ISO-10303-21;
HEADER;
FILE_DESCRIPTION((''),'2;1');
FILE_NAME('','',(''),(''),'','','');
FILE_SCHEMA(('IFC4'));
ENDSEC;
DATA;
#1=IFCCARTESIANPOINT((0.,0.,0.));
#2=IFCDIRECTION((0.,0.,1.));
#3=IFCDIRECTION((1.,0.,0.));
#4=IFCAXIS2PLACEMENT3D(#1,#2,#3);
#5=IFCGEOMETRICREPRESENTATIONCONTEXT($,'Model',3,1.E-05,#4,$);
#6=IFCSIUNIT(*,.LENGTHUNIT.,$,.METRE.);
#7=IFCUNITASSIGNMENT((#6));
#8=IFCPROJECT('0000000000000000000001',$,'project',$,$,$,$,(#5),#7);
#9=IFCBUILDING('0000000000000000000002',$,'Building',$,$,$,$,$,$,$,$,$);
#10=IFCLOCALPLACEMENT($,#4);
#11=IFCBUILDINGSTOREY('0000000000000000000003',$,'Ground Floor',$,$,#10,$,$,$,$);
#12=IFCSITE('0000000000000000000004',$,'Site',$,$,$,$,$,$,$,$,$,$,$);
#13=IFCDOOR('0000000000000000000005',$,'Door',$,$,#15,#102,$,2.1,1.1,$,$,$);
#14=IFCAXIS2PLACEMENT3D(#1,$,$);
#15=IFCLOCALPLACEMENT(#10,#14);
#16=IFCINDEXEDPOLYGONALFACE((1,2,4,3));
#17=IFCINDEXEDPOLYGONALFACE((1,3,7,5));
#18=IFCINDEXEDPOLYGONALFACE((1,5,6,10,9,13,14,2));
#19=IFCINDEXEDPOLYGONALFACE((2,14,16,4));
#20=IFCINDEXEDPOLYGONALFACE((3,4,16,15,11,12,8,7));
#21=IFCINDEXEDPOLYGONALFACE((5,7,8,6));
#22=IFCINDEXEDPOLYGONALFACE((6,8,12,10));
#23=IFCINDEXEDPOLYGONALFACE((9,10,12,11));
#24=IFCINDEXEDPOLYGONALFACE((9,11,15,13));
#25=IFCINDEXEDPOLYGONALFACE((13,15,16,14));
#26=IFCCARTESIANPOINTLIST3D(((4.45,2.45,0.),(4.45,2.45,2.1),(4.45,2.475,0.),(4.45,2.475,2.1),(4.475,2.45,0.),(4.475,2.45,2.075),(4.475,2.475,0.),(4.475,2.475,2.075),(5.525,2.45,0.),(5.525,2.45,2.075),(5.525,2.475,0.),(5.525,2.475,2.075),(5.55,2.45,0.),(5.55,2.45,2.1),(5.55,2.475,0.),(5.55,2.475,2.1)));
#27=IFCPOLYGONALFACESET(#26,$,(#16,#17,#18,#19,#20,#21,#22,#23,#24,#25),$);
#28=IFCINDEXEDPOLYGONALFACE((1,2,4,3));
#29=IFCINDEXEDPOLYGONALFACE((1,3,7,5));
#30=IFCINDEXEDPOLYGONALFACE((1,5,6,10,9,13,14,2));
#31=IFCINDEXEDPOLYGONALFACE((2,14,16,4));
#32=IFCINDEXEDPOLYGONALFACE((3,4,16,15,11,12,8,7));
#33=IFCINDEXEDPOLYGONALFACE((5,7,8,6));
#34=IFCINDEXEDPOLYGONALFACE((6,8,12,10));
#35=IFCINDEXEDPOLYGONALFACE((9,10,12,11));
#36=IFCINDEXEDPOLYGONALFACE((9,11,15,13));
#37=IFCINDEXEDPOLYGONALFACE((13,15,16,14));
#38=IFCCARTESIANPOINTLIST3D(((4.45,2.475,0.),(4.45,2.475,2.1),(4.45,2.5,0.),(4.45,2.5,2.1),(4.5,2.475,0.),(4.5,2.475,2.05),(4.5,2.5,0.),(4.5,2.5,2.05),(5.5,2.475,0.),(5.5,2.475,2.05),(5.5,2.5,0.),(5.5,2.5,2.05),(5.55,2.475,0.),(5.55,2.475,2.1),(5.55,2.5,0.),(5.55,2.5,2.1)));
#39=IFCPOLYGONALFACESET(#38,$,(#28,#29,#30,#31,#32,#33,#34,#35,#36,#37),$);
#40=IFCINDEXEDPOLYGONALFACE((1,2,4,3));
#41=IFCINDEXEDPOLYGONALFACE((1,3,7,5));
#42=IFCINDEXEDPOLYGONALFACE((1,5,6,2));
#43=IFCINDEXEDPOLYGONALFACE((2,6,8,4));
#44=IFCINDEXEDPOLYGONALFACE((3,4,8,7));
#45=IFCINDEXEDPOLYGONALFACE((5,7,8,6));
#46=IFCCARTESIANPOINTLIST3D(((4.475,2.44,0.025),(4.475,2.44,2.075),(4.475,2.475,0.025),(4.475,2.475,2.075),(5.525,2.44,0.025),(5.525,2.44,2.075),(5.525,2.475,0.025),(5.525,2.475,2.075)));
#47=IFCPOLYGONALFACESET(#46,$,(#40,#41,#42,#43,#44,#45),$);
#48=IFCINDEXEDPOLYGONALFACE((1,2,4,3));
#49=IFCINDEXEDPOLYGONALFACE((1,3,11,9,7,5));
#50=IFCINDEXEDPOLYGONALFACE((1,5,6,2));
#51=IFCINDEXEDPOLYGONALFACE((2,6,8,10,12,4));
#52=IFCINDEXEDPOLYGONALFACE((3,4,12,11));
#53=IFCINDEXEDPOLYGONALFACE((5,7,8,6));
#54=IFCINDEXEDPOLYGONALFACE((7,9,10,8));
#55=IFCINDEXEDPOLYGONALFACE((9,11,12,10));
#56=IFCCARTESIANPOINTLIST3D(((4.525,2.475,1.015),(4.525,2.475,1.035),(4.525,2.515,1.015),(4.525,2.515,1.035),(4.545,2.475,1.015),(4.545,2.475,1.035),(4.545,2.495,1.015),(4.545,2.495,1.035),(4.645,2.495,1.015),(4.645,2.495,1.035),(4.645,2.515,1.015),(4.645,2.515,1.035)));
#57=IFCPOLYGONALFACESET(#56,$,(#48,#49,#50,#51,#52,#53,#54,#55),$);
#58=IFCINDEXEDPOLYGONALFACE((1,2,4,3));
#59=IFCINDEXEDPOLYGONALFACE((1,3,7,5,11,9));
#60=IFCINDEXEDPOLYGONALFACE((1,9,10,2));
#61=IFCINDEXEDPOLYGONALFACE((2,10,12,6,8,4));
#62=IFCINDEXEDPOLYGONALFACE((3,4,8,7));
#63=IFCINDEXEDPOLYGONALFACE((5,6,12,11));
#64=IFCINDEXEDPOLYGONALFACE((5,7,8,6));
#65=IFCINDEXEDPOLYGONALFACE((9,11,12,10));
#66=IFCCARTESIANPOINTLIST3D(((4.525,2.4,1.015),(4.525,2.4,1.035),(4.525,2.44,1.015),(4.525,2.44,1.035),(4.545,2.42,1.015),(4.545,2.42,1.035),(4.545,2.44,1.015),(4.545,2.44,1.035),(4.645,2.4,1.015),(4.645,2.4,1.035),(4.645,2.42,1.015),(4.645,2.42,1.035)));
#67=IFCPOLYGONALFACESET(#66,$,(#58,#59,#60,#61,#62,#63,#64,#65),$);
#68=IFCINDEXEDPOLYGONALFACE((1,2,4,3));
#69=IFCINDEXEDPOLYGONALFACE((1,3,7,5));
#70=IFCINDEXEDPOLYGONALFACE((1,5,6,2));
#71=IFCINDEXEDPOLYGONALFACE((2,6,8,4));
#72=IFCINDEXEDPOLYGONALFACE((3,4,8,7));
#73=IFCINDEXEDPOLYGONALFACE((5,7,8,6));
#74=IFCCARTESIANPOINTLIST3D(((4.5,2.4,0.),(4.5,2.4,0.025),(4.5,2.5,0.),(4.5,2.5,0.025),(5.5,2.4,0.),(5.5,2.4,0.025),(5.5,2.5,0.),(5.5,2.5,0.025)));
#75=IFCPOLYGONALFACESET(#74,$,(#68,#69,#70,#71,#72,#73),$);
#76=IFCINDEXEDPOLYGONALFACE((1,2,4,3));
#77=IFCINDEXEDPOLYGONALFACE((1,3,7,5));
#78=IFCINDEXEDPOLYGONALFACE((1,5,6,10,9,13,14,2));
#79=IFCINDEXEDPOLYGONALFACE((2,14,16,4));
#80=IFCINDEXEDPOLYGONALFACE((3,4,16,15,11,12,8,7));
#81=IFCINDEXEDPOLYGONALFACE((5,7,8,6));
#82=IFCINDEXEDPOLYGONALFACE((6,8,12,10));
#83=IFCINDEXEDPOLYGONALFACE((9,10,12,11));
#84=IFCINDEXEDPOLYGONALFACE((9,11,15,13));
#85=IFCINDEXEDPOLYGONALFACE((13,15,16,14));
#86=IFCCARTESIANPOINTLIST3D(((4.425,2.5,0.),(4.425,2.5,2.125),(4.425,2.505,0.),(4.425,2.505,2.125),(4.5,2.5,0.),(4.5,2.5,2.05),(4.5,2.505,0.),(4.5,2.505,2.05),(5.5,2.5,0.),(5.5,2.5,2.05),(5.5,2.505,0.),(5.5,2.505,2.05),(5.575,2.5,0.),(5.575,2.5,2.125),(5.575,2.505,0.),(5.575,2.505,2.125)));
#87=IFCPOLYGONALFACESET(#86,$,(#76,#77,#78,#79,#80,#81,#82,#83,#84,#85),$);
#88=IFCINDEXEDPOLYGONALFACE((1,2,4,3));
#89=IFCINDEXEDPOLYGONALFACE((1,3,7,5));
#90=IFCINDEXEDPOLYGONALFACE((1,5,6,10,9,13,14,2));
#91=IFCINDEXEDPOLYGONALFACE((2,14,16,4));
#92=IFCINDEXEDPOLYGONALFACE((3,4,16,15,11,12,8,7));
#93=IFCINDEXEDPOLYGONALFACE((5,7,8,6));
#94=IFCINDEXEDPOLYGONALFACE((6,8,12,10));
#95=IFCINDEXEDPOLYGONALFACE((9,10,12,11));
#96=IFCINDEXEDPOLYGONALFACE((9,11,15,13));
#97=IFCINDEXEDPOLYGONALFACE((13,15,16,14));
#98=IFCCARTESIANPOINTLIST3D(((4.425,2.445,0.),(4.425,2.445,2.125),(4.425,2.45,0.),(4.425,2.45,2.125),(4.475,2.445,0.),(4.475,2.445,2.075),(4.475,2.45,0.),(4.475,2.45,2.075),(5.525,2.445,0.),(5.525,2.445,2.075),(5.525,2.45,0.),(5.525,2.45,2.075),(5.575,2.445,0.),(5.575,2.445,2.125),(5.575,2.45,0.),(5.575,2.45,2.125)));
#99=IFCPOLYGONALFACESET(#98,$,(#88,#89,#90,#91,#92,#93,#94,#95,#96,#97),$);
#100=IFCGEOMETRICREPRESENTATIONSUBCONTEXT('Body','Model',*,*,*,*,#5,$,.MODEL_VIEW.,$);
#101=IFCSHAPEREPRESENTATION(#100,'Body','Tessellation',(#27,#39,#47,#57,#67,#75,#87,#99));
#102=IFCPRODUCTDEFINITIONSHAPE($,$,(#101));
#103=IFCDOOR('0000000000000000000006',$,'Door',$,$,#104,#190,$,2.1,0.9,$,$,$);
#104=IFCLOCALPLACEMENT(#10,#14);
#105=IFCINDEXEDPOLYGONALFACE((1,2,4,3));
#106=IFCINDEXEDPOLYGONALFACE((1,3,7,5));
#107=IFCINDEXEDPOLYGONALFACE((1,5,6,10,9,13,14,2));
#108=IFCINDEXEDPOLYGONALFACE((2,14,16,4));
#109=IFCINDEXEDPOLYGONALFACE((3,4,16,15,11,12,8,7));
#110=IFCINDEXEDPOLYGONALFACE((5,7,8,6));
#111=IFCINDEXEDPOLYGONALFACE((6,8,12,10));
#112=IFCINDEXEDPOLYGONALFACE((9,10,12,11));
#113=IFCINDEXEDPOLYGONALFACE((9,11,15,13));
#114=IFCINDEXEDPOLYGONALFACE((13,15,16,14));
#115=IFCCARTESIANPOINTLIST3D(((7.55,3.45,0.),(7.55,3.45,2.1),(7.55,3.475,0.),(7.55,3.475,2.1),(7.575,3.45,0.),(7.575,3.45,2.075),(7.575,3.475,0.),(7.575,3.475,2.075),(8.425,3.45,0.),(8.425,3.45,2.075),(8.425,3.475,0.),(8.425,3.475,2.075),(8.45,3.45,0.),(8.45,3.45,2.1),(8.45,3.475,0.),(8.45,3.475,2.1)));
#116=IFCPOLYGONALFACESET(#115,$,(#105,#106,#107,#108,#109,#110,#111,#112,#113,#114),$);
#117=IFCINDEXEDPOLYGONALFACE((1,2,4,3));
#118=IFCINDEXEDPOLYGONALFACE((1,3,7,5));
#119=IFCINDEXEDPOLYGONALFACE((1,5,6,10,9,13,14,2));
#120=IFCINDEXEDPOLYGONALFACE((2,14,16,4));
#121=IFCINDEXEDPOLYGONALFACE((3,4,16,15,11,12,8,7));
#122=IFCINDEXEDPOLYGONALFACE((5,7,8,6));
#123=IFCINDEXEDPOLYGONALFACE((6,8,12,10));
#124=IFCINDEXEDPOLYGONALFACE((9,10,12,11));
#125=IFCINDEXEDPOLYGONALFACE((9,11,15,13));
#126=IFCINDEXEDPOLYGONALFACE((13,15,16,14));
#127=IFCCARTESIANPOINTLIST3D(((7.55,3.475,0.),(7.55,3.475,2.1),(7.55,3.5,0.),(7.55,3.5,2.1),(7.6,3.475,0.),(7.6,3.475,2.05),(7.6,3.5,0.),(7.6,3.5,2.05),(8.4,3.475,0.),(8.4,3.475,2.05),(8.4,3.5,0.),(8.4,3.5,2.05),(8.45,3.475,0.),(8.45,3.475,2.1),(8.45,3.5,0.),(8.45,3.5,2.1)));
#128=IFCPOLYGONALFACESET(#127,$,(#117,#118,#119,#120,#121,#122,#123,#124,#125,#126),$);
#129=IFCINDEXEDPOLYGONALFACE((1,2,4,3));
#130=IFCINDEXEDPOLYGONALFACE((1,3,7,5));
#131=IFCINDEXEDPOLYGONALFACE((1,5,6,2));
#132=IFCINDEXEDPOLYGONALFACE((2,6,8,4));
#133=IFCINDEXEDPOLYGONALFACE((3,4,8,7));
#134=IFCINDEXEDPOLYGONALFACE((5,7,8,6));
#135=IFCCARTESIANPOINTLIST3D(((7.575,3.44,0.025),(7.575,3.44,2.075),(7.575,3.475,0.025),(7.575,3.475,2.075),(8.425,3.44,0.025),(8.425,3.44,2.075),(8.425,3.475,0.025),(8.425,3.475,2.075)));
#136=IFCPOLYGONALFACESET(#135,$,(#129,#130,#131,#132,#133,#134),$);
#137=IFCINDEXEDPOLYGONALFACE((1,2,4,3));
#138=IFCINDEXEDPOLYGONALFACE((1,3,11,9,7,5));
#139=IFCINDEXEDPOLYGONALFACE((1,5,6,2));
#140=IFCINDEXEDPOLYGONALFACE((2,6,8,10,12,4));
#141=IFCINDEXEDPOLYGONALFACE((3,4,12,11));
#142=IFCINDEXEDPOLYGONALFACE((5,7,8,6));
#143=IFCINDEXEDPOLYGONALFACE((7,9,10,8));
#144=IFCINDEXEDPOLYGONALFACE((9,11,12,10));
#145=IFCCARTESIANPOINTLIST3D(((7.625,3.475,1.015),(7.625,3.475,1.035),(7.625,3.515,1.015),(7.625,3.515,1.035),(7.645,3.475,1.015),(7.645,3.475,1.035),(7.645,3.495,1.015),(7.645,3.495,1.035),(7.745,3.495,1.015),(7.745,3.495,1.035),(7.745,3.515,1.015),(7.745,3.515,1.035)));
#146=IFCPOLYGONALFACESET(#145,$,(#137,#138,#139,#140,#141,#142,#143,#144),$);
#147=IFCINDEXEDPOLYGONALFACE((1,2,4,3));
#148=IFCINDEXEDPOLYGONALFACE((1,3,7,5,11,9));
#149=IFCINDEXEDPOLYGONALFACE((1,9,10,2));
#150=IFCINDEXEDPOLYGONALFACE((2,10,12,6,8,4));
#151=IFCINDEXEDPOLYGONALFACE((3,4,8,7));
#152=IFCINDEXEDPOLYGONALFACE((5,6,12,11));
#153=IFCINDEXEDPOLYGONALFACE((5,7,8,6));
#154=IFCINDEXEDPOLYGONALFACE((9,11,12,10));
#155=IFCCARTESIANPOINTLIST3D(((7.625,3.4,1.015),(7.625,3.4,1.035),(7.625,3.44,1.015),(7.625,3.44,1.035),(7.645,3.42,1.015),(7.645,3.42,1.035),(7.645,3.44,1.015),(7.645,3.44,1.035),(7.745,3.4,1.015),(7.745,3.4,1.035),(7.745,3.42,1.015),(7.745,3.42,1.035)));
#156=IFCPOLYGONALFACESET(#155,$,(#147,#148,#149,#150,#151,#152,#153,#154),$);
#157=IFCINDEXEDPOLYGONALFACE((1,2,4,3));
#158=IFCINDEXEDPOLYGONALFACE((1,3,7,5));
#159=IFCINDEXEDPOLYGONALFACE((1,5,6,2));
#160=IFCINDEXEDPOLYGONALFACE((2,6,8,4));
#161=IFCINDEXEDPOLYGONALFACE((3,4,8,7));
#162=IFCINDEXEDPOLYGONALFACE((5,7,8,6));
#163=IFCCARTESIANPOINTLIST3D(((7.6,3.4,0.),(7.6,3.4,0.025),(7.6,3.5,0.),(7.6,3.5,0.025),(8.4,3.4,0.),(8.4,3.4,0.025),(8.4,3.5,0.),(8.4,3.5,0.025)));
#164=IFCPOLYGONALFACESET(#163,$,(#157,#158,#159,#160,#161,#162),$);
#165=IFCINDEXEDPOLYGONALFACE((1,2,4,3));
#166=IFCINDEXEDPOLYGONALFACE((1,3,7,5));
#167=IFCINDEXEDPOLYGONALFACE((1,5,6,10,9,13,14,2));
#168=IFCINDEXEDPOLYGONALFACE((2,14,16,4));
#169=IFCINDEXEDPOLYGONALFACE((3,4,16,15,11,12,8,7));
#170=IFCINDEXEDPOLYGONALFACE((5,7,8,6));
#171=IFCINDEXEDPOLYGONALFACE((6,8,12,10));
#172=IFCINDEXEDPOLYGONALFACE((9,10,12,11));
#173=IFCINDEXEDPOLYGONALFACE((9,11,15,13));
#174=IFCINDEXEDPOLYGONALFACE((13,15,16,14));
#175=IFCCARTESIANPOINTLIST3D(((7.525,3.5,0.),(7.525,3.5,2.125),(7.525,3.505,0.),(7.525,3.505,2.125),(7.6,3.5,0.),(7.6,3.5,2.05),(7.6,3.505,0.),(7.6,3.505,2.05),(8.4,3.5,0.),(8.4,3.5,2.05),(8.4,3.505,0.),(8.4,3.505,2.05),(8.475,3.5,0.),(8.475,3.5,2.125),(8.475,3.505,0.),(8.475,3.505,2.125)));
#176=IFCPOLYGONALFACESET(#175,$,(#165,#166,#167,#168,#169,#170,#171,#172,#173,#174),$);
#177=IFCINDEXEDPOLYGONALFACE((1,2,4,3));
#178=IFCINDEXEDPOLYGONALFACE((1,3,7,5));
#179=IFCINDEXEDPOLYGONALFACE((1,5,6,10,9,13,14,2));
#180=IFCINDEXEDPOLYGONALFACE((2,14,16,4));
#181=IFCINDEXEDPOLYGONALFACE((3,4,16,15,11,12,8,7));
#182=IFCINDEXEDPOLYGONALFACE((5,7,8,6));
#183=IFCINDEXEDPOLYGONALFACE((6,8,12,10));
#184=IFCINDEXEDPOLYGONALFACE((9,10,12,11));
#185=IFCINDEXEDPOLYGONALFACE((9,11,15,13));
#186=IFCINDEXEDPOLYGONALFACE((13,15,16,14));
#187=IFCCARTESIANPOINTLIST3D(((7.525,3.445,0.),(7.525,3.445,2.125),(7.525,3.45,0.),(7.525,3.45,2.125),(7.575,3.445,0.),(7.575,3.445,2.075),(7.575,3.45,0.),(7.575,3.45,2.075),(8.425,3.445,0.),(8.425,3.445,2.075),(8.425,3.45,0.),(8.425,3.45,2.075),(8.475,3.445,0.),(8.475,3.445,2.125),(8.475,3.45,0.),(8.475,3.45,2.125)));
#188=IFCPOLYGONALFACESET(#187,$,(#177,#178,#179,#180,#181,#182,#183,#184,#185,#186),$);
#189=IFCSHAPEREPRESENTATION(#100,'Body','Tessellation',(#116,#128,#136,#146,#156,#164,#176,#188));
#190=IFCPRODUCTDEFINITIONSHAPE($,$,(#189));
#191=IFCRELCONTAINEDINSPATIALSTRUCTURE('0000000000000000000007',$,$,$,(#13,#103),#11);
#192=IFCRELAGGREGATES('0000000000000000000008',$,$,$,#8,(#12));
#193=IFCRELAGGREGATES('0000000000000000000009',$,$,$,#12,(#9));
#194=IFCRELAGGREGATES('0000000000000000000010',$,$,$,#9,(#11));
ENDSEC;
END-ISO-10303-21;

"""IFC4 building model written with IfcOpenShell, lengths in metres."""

from ifc_helpers import new_model, si_unit, frame, origin_with_axes, place, context, subcontext, project, spatial, line, indexed_curve, outline, extrude, element, save


model = new_model("IFC4")

# Units and contexts
model_context = context("Model", 3, precision=1e-05, world=origin_with_axes())
body_context = subcontext(model_context, "Body", "Model", "MODEL_VIEW")
ifc_project = project(units=[si_unit("LENGTHUNIT", "METRE")], contexts=[model_context])

# Site, building, storey
site = spatial("IfcSite", under=ifc_project, Name="Site")
building = spatial("IfcBuilding", under=site, Name="Building")
storey_placement = place(None, origin_with_axes())
storey = spatial("IfcBuildingStorey", under=building, at=storey_placement, Name="Ground Floor")

# Doors
door_1_placement = place(storey_placement, frame((5.55, 2.5, 0.0), z_axis=(0.0, 0.0, 1.0), x_axis=(-1.0, 0.0, 0.0)))
element("IfcDoor", 1, at=door_1_placement, inside=storey, Name="Door", OverallHeight=2.1, OverallWidth=1.1, context=body_context, shape_type="SweptSolid", body=[
    extrude(outline(indexed_curve([(0.0, 0.0), (0.0, 2.1), (1.1, 2.1), (1.1, 0.0), (1.075, 0.0), (1.075, 2.075), (0.025, 2.075), (0.025, 0.0)], segments=[line(1, 2, 3, 4, 5, 6, 7, 8, 1)])), frame((0.0, 0.025, 0.0), z_axis=(0.0, -1.0, 0.0), x_axis=(1.0, 0.0, 0.0)), (0.0, 0.0, -1.0), 0.025),
    extrude(outline(indexed_curve([(0.0, 0.0), (0.0, 2.1), (1.1, 2.1), (1.1, 0.0), (1.05, 0.0), (1.05, 2.05), (0.05, 2.05), (0.05, 0.0)], segments=[line(1, 2, 3, 4, 5, 6, 7, 8, 1)])), frame((0.0, 0.0, 0.0), z_axis=(0.0, -1.0, 0.0), x_axis=(1.0, 0.0, 0.0)), (0.0, 0.0, -1.0), 0.025),
    extrude(outline(indexed_curve([(0.0, 0.0), (1.05, 0.0), (1.05, 0.035), (0.0, 0.035)], segments=[line(1, 2, 3, 4, 1)])), frame((0.025, 0.025, 0.025), z_axis=(0.0, 0.0, 1.0), x_axis=(1.0, 0.0, 0.0)), (0.0, 0.0, 1.0), 2.05),
    extrude(outline(indexed_curve([(0.0, 0.0), (0.0, -0.04), (-0.12, -0.04), (-0.12, -0.02), (-0.02, -0.02), (-0.02, 0.0)], segments=[line(1, 2, 3, 4, 5, 6, 1)])), frame((1.025, 0.025, 1.015), z_axis=(0.0, 0.0, 1.0), x_axis=(1.0, 0.0, 0.0)), (0.0, 0.0, 1.0), 0.02),
    extrude(outline(indexed_curve([(0.0, 0.0), (0.0, 0.04), (-0.12, 0.04), (-0.12, 0.02), (-0.02, 0.02), (-0.02, 0.0)], segments=[line(1, 2, 3, 4, 5, 6, 1)])), frame((1.025, 0.06, 1.015), z_axis=(0.0, 0.0, 1.0), x_axis=(1.0, 0.0, 0.0)), (0.0, 0.0, 1.0), 0.02),
    extrude(outline(indexed_curve([(0.0, 0.0), (1.0, 0.0), (1.0, 0.1), (0.0, 0.1)], segments=[line(1, 2, 3, 4, 1)])), frame((0.05, 0.0, 0.0), z_axis=(0.0, 0.0, 1.0), x_axis=(1.0, 0.0, 0.0)), (0.0, 0.0, 1.0), 0.025),
    extrude(outline(indexed_curve([(0.0, 0.0), (0.0, 2.125), (1.15, 2.125), (1.15, 0.0), (1.075, 0.0), (1.075, 2.05), (0.075, 2.05), (0.075, 0.0)], segments=[line(1, 2, 3, 4, 5, 6, 7, 8, 1)])), frame((-0.025, -0.005, 0.0), z_axis=(0.0, -1.0, 0.0), x_axis=(1.0, 0.0, 0.0)), (0.0, 0.0, -1.0), 0.005),
    extrude(outline(indexed_curve([(0.0, 0.0), (0.0, 2.125), (1.15, 2.125), (1.15, 0.0), (1.1, 0.0), (1.1, 2.075), (0.05, 2.075), (0.05, 0.0)], segments=[line(1, 2, 3, 4, 5, 6, 7, 8, 1)])), frame((-0.025, 0.05, 0.0), z_axis=(0.0, -1.0, 0.0), x_axis=(1.0, 0.0, 0.0)), (0.0, 0.0, -1.0), 0.005),
])
door_2_placement = place(storey_placement, frame((8.45, 3.5, 0.0), z_axis=(0.0, 0.0, 1.0), x_axis=(-1.0, 0.0, 0.0)))
element("IfcDoor", 2, at=door_2_placement, inside=storey, Name="Door", OverallHeight=2.1, OverallWidth=0.9, context=body_context, shape_type="SweptSolid", body=[
    extrude(outline(indexed_curve([(0.0, 0.0), (0.0, 2.1), (0.9, 2.1), (0.9, 0.0), (0.875, 0.0), (0.875, 2.075), (0.025, 2.075), (0.025, 0.0)], segments=[line(1, 2, 3, 4, 5, 6, 7, 8, 1)])), frame((0.0, 0.025, 0.0), z_axis=(0.0, -1.0, 0.0), x_axis=(1.0, 0.0, 0.0)), (0.0, 0.0, -1.0), 0.025),
    extrude(outline(indexed_curve([(0.0, 0.0), (0.0, 2.1), (0.9, 2.1), (0.9, 0.0), (0.85, 0.0), (0.85, 2.05), (0.05, 2.05), (0.05, 0.0)], segments=[line(1, 2, 3, 4, 5, 6, 7, 8, 1)])), frame((0.0, 0.0, 0.0), z_axis=(0.0, -1.0, 0.0), x_axis=(1.0, 0.0, 0.0)), (0.0, 0.0, -1.0), 0.025),
    extrude(outline(indexed_curve([(0.0, 0.0), (0.85, 0.0), (0.85, 0.035), (0.0, 0.035)], segments=[line(1, 2, 3, 4, 1)])), frame((0.025, 0.025, 0.025), z_axis=(0.0, 0.0, 1.0), x_axis=(1.0, 0.0, 0.0)), (0.0, 0.0, 1.0), 2.05),
    extrude(outline(indexed_curve([(0.0, 0.0), (0.0, -0.04), (-0.12, -0.04), (-0.12, -0.02), (-0.02, -0.02), (-0.02, 0.0)], segments=[line(1, 2, 3, 4, 5, 6, 1)])), frame((0.825, 0.025, 1.015), z_axis=(0.0, 0.0, 1.0), x_axis=(1.0, 0.0, 0.0)), (0.0, 0.0, 1.0), 0.02),
    extrude(outline(indexed_curve([(0.0, 0.0), (0.0, 0.04), (-0.12, 0.04), (-0.12, 0.02), (-0.02, 0.02), (-0.02, 0.0)], segments=[line(1, 2, 3, 4, 5, 6, 1)])), frame((0.825, 0.06, 1.015), z_axis=(0.0, 0.0, 1.0), x_axis=(1.0, 0.0, 0.0)), (0.0, 0.0, 1.0), 0.02),
    extrude(outline(indexed_curve([(0.0, 0.0), (0.8, 0.0), (0.8, 0.1), (0.0, 0.1)], segments=[line(1, 2, 3, 4, 1)])), frame((0.05, 0.0, 0.0), z_axis=(0.0, 0.0, 1.0), x_axis=(1.0, 0.0, 0.0)), (0.0, 0.0, 1.0), 0.025),
    extrude(outline(indexed_curve([(0.0, 0.0), (0.0, 2.125), (0.95, 2.125), (0.95, 0.0), (0.875, 0.0), (0.875, 2.05), (0.075, 2.05), (0.075, 0.0)], segments=[line(1, 2, 3, 4, 5, 6, 7, 8, 1)])), frame((-0.025, -0.005, 0.0), z_axis=(0.0, -1.0, 0.0), x_axis=(1.0, 0.0, 0.0)), (0.0, 0.0, -1.0), 0.005),
    extrude(outline(indexed_curve([(0.0, 0.0), (0.0, 2.125), (0.95, 2.125), (0.95, 0.0), (0.9, 0.0), (0.9, 2.075), (0.05, 2.075), (0.05, 0.0)], segments=[line(1, 2, 3, 4, 5, 6, 7, 8, 1)])), frame((-0.025, 0.05, 0.0), z_axis=(0.0, -1.0, 0.0), x_axis=(1.0, 0.0, 0.0)), (0.0, 0.0, -1.0), 0.005),
])

save(model, "model.ifc")
